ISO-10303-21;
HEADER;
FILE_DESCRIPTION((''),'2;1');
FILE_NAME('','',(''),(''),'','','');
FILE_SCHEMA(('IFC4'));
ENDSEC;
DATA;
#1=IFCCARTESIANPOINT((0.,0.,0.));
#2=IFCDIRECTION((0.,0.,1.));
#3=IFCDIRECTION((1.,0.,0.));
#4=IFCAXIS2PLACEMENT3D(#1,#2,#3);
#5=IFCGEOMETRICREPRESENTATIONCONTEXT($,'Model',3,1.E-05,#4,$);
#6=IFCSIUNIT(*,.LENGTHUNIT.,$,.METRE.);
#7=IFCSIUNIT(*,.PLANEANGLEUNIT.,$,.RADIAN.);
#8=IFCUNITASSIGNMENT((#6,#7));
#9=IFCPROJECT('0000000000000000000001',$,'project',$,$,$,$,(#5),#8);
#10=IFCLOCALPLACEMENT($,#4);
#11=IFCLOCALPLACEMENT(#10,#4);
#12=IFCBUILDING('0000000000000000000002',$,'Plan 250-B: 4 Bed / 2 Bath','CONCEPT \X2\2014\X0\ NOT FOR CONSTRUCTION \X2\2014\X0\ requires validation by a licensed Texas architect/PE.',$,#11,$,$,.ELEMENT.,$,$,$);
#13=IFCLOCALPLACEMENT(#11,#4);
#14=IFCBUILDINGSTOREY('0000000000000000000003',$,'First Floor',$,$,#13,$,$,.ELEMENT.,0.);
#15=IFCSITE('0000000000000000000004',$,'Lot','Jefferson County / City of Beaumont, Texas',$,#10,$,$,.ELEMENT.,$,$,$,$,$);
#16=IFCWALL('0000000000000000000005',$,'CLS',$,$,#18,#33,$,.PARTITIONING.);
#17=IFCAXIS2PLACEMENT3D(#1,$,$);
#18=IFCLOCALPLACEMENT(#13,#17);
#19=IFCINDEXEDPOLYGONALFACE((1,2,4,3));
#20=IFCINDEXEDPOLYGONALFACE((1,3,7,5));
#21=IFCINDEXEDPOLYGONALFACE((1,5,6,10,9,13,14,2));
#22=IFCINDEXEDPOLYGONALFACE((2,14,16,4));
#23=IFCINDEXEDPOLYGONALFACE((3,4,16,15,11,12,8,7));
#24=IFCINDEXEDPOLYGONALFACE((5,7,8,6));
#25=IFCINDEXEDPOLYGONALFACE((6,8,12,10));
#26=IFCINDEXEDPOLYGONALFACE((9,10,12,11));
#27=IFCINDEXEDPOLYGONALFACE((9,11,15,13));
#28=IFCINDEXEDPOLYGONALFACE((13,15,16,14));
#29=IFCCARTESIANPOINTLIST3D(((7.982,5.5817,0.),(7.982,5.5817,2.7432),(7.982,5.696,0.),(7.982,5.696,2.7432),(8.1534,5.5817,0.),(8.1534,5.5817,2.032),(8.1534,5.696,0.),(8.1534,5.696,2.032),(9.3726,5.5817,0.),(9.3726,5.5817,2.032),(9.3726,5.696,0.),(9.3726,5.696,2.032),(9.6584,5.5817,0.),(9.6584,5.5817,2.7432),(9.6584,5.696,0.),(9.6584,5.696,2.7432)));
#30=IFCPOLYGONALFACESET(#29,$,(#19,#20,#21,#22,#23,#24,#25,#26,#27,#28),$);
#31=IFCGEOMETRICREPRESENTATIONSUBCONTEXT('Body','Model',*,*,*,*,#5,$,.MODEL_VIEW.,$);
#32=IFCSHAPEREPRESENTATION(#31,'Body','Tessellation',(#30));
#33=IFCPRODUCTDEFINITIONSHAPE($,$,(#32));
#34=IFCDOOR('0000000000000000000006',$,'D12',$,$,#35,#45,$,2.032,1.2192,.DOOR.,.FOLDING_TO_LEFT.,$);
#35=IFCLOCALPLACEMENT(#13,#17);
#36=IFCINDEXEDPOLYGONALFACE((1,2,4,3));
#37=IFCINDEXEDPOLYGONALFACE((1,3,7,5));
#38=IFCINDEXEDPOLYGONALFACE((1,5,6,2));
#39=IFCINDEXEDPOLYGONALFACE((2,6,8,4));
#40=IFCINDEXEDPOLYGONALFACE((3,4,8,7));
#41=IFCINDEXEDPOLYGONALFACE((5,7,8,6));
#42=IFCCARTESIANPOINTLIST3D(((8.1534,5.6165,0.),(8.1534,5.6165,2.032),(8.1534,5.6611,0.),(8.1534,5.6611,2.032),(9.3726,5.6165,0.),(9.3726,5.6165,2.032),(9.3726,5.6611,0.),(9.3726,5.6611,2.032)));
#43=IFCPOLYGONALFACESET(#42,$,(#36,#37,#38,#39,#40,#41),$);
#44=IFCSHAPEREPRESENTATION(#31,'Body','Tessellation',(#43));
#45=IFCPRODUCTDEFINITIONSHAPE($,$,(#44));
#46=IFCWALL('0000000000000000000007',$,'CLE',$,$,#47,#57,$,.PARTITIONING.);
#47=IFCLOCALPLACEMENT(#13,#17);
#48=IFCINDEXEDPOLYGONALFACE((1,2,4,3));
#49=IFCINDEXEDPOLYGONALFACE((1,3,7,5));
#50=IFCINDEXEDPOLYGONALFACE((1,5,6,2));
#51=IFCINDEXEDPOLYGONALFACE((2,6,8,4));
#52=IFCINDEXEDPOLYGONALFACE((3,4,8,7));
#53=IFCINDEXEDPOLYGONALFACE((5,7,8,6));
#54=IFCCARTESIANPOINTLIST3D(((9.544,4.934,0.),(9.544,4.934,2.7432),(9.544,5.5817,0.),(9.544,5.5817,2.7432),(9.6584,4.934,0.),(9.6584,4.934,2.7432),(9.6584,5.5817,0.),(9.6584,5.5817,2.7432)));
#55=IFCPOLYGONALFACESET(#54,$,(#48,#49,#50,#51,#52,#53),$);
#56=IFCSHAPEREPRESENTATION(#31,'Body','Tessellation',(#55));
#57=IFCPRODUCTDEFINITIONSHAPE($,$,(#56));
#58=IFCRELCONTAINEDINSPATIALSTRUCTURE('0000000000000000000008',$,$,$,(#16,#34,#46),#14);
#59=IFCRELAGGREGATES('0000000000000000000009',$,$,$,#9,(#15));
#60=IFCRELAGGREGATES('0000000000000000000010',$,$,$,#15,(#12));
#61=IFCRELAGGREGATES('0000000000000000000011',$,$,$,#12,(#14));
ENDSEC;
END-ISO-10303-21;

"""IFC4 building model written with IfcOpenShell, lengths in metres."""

from ifc_helpers import new_model, si_unit, frame, frame_2d, origin_with_axes, place, context, subcontext, project, spatial, rectangle, extrude, element, fill, save


model = new_model("IFC4")

# Units and contexts
model_context = context("Model", 3, precision=1e-05, world=origin_with_axes())
body_context = subcontext(model_context, "Body", "Model", "MODEL_VIEW")
ifc_project = project(units=[si_unit("LENGTHUNIT", "METRE"), si_unit("PLANEANGLEUNIT", "RADIAN")], contexts=[model_context])

# Site, building, storey
site_placement = place(None, origin_with_axes())
site = spatial("IfcSite", under=ifc_project, at=site_placement, Name="Lot", Description="Jefferson County / City of Beaumont, Texas", CompositionType="ELEMENT")
building_placement = place(site_placement, origin_with_axes())
building = spatial("IfcBuilding", under=site, at=building_placement, Name="Plan 250-B: 4 Bed / 2 Bath", Description="CONCEPT — NOT FOR CONSTRUCTION — requires validation by a licensed Texas architect/PE.", CompositionType="ELEMENT")
storey_placement = place(building_placement, origin_with_axes())
storey = spatial("IfcBuildingStorey", under=building, at=storey_placement, Name="First Floor", CompositionType="ELEMENT", Elevation=0.0)

# Wall, opening, door
wall_1_placement = place(storey_placement, frame((7.982, 5.6388, 0.0), z_axis=(0.0, 0.0, 1.0), x_axis=(1.0, 0.0, 0.0)))
wall_1 = element("IfcWall", 1, at=wall_1_placement, inside=storey, Name="CLS", PredefinedType="PARTITIONING", context=body_context, shape_type="SweptSolid", body=[
    extrude(rectangle(XDim=1.6764, YDim=0.1143, at=frame_2d((0.8382, 0.0), x_axis=(1.0, 0.0))), origin_with_axes(), (0.0, 0.0, 1.0), 2.7432),
])
opening_1_placement = place(wall_1_placement, frame((0.1715, 0.0, 0.0), z_axis=(0.0, 0.0, 1.0), x_axis=(1.0, 0.0, 0.0)))
opening_1 = element("IfcOpeningElement", 2, at=opening_1_placement, cuts=wall_1, PredefinedType="OPENING", context=body_context, shape_type="SweptSolid", body=[
    extrude(rectangle(XDim=1.2192, YDim=0.1448, at=frame_2d((0.6096, 0.0), x_axis=(1.0, 0.0))), origin_with_axes(), (0.0, 0.0, 1.0), 2.032),
])
door_1_placement = place(opening_1_placement, origin_with_axes())
door_1 = element("IfcDoor", 3, at=door_1_placement, inside=storey, Name="D12", OperationType="FOLDING_TO_LEFT", OverallHeight=2.032, OverallWidth=1.2192, PredefinedType="DOOR", context=body_context, shape_type="SweptSolid", body=[
    extrude(rectangle(XDim=1.2192, YDim=0.0445, at=frame_2d((0.6096, 0.0), x_axis=(1.0, 0.0))), origin_with_axes(), (0.0, 0.0, 1.0), 2.032),
])
fill(opening_1, door_1)

# Wall
wall_2_placement = place(storey_placement, frame((9.6012, 4.934, 0.0), z_axis=(0.0, 0.0, 1.0), x_axis=(0.0, 1.0, 0.0)))
element("IfcWall", 4, at=wall_2_placement, inside=storey, Name="CLE", PredefinedType="PARTITIONING", context=body_context, shape_type="SweptSolid", body=[
    extrude(rectangle(XDim=0.6477, YDim=0.1143, at=frame_2d((0.3239, 0.0), x_axis=(1.0, 0.0))), origin_with_axes(), (0.0, 0.0, 1.0), 2.7432),
])

save(model, "model.ifc")
